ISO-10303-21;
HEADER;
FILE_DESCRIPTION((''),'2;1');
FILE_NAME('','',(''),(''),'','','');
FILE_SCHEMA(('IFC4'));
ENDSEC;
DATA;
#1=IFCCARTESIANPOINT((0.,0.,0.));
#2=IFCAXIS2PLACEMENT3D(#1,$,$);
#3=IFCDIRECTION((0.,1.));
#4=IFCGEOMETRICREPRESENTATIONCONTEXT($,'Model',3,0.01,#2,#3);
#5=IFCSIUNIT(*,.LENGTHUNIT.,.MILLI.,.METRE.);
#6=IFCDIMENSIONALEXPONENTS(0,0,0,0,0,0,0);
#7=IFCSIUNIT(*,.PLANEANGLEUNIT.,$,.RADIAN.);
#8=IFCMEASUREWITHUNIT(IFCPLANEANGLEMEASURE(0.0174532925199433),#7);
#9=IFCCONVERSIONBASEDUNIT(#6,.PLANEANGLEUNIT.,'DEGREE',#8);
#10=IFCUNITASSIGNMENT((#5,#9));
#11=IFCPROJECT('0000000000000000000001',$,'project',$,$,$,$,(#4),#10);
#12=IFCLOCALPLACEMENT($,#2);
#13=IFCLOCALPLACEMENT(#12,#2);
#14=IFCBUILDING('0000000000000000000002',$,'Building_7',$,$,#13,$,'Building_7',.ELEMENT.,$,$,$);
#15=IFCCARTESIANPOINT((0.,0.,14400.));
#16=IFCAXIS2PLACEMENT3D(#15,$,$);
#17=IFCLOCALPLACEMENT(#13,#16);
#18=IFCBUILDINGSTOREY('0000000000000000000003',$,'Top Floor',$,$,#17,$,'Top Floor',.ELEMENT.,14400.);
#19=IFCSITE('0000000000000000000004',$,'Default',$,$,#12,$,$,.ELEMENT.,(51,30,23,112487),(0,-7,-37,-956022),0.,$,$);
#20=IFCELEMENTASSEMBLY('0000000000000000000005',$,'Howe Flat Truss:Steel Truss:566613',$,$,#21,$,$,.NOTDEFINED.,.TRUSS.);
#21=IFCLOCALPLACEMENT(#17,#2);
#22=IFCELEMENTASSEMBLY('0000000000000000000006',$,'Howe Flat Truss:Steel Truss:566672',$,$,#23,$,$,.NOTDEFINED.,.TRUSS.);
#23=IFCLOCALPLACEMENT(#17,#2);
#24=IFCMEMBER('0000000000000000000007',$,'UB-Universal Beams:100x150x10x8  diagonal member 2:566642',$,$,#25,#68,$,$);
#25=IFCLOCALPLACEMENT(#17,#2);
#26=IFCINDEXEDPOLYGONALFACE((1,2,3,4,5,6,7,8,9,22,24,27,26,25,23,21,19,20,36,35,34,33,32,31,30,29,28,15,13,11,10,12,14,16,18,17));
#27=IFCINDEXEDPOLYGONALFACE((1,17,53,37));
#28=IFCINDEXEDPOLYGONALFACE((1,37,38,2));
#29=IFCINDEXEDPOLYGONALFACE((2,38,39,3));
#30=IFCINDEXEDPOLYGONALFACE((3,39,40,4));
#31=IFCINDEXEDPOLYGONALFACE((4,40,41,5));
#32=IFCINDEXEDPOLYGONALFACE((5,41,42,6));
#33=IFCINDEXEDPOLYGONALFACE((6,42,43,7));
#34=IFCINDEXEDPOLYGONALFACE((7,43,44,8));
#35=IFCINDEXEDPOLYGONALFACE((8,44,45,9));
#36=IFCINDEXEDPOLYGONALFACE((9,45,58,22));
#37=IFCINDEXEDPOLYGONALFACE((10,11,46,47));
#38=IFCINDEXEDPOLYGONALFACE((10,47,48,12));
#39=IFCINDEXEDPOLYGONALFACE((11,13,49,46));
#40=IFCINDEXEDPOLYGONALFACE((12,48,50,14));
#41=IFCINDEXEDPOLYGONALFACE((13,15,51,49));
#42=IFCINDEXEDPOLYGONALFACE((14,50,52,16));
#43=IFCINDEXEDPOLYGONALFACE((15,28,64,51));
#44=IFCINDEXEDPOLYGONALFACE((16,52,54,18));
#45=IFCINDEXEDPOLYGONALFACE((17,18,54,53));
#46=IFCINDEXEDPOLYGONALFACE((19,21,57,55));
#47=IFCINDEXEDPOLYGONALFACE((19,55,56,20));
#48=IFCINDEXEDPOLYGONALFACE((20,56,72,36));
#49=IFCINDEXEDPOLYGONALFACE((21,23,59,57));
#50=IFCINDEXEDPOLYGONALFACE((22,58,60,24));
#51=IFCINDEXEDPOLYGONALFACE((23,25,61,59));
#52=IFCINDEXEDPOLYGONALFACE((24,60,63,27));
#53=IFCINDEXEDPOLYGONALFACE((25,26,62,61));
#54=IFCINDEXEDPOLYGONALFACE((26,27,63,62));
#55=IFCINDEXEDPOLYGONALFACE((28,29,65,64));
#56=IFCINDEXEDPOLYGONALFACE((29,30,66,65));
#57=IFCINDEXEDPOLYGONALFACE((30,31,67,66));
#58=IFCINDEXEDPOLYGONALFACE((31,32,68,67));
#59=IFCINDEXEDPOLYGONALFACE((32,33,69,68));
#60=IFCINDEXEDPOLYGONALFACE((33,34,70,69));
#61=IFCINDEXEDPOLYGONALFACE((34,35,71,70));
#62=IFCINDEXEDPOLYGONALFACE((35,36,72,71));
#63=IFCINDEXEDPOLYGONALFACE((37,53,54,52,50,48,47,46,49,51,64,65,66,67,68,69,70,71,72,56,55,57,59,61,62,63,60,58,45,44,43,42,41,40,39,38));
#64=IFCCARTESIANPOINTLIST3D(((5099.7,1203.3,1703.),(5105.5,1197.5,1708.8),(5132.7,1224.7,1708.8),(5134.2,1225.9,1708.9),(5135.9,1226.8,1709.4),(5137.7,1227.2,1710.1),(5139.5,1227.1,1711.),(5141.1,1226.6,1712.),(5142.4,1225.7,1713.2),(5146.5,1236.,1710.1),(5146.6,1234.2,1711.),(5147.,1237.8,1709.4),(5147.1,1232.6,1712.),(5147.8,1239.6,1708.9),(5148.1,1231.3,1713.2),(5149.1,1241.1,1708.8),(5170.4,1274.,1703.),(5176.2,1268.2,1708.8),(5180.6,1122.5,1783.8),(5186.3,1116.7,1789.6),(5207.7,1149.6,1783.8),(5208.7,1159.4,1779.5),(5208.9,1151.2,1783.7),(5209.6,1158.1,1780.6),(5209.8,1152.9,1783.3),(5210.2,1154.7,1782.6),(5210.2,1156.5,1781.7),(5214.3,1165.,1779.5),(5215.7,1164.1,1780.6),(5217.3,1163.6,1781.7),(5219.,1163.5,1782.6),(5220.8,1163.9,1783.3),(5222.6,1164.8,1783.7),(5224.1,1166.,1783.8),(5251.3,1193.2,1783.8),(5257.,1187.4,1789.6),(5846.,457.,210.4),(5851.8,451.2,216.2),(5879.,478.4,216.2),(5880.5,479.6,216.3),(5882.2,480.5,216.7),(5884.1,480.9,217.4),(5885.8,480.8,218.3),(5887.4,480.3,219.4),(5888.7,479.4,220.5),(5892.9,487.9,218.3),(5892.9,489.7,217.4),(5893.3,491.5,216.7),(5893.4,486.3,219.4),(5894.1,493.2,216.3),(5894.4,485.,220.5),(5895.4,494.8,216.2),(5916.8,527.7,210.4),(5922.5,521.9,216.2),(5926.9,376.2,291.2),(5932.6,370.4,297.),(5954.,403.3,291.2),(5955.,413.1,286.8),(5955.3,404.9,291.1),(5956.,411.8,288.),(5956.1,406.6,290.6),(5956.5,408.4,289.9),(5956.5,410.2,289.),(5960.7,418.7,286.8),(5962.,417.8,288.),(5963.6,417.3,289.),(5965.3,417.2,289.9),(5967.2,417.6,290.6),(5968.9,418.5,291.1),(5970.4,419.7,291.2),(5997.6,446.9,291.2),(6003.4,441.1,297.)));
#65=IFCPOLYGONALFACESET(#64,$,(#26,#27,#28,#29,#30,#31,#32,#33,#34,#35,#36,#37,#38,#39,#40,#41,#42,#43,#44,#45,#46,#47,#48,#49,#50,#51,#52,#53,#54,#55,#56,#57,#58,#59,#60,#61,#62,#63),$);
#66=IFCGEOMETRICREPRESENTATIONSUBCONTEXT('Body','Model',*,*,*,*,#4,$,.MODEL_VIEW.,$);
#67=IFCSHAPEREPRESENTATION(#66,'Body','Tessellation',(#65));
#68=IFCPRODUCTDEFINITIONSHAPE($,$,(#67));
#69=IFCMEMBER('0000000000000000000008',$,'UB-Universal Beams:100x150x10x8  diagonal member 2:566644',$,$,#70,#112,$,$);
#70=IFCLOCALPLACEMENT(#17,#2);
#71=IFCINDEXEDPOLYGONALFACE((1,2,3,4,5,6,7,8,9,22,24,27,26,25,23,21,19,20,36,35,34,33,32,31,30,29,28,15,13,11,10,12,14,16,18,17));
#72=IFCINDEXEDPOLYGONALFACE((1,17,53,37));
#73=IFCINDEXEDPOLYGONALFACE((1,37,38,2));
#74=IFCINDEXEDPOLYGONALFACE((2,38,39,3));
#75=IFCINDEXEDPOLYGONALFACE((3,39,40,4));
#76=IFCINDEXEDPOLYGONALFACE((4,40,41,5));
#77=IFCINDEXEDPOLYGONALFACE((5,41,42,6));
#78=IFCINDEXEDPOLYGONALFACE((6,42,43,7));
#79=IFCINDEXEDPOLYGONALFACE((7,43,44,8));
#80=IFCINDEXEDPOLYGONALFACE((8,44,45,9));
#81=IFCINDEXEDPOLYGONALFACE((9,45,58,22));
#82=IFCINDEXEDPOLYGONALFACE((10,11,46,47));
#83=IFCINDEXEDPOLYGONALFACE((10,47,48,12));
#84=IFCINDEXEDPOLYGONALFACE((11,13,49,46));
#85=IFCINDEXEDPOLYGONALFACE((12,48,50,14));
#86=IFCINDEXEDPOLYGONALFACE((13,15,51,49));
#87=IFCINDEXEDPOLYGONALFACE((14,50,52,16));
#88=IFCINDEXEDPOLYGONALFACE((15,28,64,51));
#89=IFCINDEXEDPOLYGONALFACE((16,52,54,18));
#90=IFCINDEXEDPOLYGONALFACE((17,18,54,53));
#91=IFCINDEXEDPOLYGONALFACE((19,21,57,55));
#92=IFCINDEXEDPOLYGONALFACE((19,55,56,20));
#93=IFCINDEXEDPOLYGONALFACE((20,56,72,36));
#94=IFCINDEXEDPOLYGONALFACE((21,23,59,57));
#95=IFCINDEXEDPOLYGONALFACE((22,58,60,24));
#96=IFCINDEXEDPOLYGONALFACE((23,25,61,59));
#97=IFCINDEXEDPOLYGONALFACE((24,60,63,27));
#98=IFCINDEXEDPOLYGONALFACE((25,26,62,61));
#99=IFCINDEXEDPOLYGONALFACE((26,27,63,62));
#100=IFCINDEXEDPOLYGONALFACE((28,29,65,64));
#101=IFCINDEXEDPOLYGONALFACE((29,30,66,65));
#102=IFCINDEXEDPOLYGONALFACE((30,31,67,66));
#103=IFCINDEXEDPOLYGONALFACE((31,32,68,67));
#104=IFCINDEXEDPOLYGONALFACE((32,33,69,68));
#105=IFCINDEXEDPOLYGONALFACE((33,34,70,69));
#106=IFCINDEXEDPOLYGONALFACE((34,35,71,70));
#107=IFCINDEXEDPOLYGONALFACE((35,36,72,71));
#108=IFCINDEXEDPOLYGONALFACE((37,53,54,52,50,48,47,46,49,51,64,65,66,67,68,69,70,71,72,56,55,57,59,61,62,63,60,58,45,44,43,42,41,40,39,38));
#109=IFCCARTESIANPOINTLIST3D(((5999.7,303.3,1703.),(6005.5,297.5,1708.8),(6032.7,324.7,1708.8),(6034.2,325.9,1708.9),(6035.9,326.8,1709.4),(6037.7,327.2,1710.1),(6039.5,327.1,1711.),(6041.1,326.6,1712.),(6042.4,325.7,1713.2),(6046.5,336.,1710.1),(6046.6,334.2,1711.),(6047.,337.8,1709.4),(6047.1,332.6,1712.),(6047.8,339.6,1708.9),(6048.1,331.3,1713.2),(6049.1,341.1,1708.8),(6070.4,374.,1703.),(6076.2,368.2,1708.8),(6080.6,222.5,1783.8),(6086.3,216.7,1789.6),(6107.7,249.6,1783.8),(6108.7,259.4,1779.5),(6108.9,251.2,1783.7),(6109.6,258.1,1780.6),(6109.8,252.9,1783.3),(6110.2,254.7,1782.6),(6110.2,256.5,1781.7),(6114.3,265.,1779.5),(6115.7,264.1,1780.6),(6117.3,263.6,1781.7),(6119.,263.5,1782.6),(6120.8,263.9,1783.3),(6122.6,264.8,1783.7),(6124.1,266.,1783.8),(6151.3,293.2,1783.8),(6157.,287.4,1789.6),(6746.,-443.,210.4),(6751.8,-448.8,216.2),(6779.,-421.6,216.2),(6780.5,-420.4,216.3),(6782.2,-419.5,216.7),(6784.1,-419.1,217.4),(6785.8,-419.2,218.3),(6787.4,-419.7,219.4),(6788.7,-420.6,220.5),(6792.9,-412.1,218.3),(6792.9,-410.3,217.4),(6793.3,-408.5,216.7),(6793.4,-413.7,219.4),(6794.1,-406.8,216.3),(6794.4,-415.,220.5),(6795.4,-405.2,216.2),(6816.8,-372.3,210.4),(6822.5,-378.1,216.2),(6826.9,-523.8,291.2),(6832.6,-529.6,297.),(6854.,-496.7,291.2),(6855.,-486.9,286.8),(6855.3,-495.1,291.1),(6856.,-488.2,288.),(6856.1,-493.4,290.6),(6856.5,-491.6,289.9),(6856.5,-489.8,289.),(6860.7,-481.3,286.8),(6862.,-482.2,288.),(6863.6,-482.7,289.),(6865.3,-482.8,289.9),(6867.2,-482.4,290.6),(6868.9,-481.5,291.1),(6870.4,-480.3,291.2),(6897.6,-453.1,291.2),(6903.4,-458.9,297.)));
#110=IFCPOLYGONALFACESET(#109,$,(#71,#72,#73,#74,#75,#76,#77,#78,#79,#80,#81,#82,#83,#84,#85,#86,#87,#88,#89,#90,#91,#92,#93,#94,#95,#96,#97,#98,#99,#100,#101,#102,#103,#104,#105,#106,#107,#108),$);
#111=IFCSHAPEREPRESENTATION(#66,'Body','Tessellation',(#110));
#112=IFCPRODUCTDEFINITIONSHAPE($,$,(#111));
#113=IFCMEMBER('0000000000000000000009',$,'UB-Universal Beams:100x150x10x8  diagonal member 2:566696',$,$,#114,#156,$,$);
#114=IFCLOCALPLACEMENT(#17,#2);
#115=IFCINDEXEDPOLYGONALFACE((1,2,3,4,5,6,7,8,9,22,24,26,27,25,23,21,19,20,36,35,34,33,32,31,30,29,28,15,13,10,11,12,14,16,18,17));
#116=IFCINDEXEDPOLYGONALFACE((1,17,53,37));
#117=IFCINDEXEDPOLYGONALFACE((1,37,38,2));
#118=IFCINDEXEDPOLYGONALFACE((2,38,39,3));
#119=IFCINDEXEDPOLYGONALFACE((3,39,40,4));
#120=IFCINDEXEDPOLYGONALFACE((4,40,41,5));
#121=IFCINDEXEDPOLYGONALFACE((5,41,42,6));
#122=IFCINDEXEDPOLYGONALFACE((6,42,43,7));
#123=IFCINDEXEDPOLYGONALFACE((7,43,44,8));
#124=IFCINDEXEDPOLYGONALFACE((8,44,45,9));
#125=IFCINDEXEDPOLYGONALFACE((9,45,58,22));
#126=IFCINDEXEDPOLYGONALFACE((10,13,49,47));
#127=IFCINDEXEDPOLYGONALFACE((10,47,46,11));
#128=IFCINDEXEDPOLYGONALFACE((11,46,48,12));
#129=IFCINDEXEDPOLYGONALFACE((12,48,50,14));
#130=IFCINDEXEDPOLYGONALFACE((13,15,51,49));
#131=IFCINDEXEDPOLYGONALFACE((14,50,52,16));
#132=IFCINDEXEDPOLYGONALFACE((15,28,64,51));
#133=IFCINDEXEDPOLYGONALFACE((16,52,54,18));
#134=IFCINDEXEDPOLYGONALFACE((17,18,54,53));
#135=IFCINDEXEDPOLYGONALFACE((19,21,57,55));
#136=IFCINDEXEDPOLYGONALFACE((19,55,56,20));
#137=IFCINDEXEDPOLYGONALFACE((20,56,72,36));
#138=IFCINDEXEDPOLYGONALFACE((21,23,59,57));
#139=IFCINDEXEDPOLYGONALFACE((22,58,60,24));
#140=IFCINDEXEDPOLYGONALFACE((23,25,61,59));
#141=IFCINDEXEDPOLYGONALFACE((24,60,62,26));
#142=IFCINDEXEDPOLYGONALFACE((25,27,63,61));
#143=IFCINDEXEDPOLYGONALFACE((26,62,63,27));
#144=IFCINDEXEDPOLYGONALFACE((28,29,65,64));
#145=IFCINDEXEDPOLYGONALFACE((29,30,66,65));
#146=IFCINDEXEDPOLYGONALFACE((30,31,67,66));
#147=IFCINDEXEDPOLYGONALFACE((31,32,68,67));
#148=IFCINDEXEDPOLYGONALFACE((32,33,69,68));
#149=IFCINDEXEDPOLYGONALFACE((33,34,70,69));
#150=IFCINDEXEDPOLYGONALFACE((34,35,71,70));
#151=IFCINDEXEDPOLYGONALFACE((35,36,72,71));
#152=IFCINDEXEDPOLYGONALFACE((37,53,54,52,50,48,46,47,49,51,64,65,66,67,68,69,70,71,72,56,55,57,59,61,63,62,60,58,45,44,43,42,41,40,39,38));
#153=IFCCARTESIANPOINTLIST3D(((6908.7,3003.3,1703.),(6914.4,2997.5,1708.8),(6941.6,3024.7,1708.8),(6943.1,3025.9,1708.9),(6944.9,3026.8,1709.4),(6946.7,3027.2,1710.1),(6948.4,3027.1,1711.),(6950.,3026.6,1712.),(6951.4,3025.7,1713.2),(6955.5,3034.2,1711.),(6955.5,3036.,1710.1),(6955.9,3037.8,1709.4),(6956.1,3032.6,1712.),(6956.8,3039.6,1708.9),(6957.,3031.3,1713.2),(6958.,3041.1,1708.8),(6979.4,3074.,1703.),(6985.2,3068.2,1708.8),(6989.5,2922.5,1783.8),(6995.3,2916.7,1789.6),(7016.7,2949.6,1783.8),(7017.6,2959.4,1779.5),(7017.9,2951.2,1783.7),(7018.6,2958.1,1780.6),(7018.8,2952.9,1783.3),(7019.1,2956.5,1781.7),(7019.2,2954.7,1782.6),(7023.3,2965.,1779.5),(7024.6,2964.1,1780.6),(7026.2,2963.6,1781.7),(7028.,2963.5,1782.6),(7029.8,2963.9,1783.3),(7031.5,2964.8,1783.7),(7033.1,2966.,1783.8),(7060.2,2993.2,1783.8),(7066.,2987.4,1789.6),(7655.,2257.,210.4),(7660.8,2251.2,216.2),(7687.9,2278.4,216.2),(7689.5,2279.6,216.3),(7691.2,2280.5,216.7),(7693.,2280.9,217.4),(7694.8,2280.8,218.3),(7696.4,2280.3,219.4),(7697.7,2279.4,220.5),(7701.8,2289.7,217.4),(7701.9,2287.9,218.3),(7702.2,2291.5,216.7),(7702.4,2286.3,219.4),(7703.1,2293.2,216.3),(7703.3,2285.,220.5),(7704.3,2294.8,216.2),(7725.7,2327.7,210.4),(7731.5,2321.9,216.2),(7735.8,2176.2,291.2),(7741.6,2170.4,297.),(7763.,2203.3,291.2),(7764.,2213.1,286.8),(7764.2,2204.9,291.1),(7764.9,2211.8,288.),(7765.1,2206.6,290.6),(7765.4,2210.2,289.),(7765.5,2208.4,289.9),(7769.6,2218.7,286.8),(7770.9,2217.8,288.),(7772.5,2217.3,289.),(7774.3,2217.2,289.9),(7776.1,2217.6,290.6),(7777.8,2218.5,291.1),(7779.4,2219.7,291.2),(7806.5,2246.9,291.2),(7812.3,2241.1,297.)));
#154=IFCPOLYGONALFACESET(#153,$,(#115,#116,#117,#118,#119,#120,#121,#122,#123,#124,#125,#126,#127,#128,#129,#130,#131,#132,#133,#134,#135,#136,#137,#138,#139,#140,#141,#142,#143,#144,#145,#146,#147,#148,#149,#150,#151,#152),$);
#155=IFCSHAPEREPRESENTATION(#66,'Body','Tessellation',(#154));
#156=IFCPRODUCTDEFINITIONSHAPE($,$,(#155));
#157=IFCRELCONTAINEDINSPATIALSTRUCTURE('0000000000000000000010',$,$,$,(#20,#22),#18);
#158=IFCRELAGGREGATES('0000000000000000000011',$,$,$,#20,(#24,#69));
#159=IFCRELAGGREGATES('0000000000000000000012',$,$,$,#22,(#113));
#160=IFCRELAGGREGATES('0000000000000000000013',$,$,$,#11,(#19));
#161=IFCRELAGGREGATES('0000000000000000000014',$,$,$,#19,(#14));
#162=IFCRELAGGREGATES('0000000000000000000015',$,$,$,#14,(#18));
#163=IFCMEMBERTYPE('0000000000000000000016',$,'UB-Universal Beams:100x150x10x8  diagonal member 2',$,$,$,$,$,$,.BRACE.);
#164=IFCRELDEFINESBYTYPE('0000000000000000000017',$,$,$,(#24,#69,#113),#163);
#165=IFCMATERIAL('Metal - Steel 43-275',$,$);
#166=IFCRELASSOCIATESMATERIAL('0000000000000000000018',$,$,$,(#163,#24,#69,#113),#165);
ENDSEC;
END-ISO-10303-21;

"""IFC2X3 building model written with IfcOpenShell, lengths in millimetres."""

from ifc_helpers import new_model, entity, si_unit, converted_unit, direction, frame, frame_2d, origin, place, context, subcontext, project, spatial, polyline, circle_curve, parameter, trimmed, segment, composite_curve, outline, extrude, source, transform, mapped, material, type_object, type_shapes, element, aggregate, save


model = new_model("IFC2X3")

# Units and contexts
model_context = context("Model", 3, precision=0.01, world=origin(), true_north=direction((0.0, 1.0)))
body_context = subcontext(model_context, "Body", "Model", "MODEL_VIEW")
ifc_project = project(units=[si_unit("LENGTHUNIT", "METRE", prefix="MILLI"), converted_unit("PLANEANGLEUNIT", "DEGREE", entity("IfcPlaneAngleMeasure", 0.0174532925199433), si_unit("PLANEANGLEUNIT", "RADIAN"), dimensions=[0, 0, 0, 0, 0, 0, 0])], contexts=[model_context])

# Site, building, storey
site_placement = place(None, origin())
site = spatial("IfcSite", under=ifc_project, at=site_placement, Name="Default", CompositionType="ELEMENT", RefLatitude=(51, 30, 23, 112487), RefLongitude=(0, -7, -37, -956022), RefElevation=0.0)
building_placement = place(site_placement, origin())
building = spatial("IfcBuilding", under=site, at=building_placement, Name="Building_7", LongName="Building_7", CompositionType="ELEMENT")
storey_placement = place(building_placement, frame((0.0, 0.0, 14400.0)))
storey = spatial("IfcBuildingStorey", under=building, at=storey_placement, Name="Top Floor", LongName="Top Floor", CompositionType="ELEMENT", Elevation=14400.0)

# Shared definitions
ifc_material = material(Name="Metal - Steel 43-275")

# Element assemblies
assembly_1_placement = place(storey_placement, origin())
assembly_1 = element("IfcElementAssembly", 1, at=assembly_1_placement, inside=storey, Name="Howe Flat Truss:Steel Truss:566613", AssemblyPlace="NOTDEFINED", PredefinedType="TRUSS")
assembly_2_placement = place(storey_placement, origin())
assembly_2 = element("IfcElementAssembly", 2, at=assembly_2_placement, inside=storey, Name="Howe Flat Truss:Steel Truss:566672", AssemblyPlace="NOTDEFINED", PredefinedType="TRUSS")

# Members
member_type_1 = type_object("IfcMemberType", Name="UB-Universal Beams:100x150x10x8  diagonal member 2", PredefinedType="BRACE", material=ifc_material)
shared_shape_1 = source(origin(), body_context, "Body", "SweptSolid", [
    extrude(outline(composite_curve([segment(polyline([(-50.0, -65.0), (-50.0, -75.0)]), True, "CONTINUOUS"), segment(polyline([(-50.0, -75.0), (50.0, -75.0)]), True, "CONTINUOUS"), segment(polyline([(50.0, -75.0), (50.0, -65.0)]), True, "CONTINUOUS"), segment(polyline([(50.0, -65.0), (11.6, -65.0)]), True, "CONTINUOUS"), segment(trimmed(circle_curve(frame_2d((11.6, -57.4), x_axis=(1.0, 0.0)), 7.6), [parameter(180.0)], [parameter(270.0)], True, "PARAMETER"), False, "CONTINUOUS"), segment(polyline([(4.0, -57.4), (4.0, 57.4)]), True, "CONTINUOUS"), segment(trimmed(circle_curve(frame_2d((11.6, 57.4), x_axis=(1.0, 0.0)), 7.6), [parameter(90.0)], [parameter(180.0)], True, "PARAMETER"), False, "CONTINUOUS"), segment(polyline([(11.6, 65.0), (50.0, 65.0)]), True, "CONTINUOUS"), segment(polyline([(50.0, 65.0), (50.0, 75.0)]), True, "CONTINUOUS"), segment(polyline([(50.0, 75.0), (-50.0, 75.0)]), True, "CONTINUOUS"), segment(polyline([(-50.0, 75.0), (-50.0, 65.0)]), True, "CONTINUOUS"), segment(polyline([(-50.0, 65.0), (-11.6, 65.0)]), True, "CONTINUOUS"), segment(trimmed(circle_curve(frame_2d((-11.6, 57.4), x_axis=(1.0, 0.0)), 7.6), [parameter(360.0)], [parameter(90.0)], True, "PARAMETER"), False, "CONTINUOUS"), segment(polyline([(-4.0, 57.4), (-4.0, -57.4)]), True, "CONTINUOUS"), segment(trimmed(circle_curve(frame_2d((-11.6, -57.4), x_axis=(1.0, 0.0)), 7.6), [parameter(270.0)], [parameter(360.0)], True, "PARAMETER"), False, "CONTINUOUS"), segment(polyline([(-11.6, -65.0), (-50.0, -65.0)]), True, "CONTINUOUS")], self_intersect=False)), frame((-914.0, 0.0, 0.0), z_axis=(-1.0, 0.0, 0.0), x_axis=(0.0, -1.0, 0.0)), (0.0, 0.0, -1.0), 1828.1),
])
type_shapes(member_type_1, [shared_shape_1])
member_1_placement = place(assembly_1_placement, frame((5551.5, 822.2, 1000.0), z_axis=(-0.57735, 0.57735, -0.57735), x_axis=(0.408248, -0.408248, -0.816497)))
member_1 = element("IfcMember", 3, at=member_1_placement, type_object=member_type_1, material=ifc_material, Name="UB-Universal Beams:100x150x10x8  diagonal member 2:566642", context=body_context, shape_type="MappedRepresentation", body=[
    mapped(shared_shape_1, transform((0.0, 0.0, 0.0), scale=1.0)),
])
member_2_placement = place(assembly_1_placement, frame((6451.5, -77.8, 1000.0), z_axis=(-0.57735, 0.57735, -0.57735), x_axis=(0.408248, -0.408248, -0.816497)))
member_2 = element("IfcMember", 4, at=member_2_placement, type_object=member_type_1, material=ifc_material, Name="UB-Universal Beams:100x150x10x8  diagonal member 2:566644", context=body_context, shape_type="MappedRepresentation", body=[
    mapped(shared_shape_1, transform((0.0, 0.0, 0.0), scale=1.0)),
])
member_3_placement = place(assembly_2_placement, frame((7360.5, 2622.2, 1000.0), z_axis=(-0.57735, 0.57735, -0.57735), x_axis=(-0.408248, 0.408248, 0.816497)))
member_3 = element("IfcMember", 5, at=member_3_placement, type_object=member_type_1, material=ifc_material, Name="UB-Universal Beams:100x150x10x8  diagonal member 2:566696", context=body_context, shape_type="MappedRepresentation", body=[
    mapped(shared_shape_1, transform((0.0, 0.0, 0.0), scale=1.0)),
])
aggregate(assembly_1, [member_1, member_2])
aggregate(assembly_2, [member_3])

save(model, "model.ifc")
